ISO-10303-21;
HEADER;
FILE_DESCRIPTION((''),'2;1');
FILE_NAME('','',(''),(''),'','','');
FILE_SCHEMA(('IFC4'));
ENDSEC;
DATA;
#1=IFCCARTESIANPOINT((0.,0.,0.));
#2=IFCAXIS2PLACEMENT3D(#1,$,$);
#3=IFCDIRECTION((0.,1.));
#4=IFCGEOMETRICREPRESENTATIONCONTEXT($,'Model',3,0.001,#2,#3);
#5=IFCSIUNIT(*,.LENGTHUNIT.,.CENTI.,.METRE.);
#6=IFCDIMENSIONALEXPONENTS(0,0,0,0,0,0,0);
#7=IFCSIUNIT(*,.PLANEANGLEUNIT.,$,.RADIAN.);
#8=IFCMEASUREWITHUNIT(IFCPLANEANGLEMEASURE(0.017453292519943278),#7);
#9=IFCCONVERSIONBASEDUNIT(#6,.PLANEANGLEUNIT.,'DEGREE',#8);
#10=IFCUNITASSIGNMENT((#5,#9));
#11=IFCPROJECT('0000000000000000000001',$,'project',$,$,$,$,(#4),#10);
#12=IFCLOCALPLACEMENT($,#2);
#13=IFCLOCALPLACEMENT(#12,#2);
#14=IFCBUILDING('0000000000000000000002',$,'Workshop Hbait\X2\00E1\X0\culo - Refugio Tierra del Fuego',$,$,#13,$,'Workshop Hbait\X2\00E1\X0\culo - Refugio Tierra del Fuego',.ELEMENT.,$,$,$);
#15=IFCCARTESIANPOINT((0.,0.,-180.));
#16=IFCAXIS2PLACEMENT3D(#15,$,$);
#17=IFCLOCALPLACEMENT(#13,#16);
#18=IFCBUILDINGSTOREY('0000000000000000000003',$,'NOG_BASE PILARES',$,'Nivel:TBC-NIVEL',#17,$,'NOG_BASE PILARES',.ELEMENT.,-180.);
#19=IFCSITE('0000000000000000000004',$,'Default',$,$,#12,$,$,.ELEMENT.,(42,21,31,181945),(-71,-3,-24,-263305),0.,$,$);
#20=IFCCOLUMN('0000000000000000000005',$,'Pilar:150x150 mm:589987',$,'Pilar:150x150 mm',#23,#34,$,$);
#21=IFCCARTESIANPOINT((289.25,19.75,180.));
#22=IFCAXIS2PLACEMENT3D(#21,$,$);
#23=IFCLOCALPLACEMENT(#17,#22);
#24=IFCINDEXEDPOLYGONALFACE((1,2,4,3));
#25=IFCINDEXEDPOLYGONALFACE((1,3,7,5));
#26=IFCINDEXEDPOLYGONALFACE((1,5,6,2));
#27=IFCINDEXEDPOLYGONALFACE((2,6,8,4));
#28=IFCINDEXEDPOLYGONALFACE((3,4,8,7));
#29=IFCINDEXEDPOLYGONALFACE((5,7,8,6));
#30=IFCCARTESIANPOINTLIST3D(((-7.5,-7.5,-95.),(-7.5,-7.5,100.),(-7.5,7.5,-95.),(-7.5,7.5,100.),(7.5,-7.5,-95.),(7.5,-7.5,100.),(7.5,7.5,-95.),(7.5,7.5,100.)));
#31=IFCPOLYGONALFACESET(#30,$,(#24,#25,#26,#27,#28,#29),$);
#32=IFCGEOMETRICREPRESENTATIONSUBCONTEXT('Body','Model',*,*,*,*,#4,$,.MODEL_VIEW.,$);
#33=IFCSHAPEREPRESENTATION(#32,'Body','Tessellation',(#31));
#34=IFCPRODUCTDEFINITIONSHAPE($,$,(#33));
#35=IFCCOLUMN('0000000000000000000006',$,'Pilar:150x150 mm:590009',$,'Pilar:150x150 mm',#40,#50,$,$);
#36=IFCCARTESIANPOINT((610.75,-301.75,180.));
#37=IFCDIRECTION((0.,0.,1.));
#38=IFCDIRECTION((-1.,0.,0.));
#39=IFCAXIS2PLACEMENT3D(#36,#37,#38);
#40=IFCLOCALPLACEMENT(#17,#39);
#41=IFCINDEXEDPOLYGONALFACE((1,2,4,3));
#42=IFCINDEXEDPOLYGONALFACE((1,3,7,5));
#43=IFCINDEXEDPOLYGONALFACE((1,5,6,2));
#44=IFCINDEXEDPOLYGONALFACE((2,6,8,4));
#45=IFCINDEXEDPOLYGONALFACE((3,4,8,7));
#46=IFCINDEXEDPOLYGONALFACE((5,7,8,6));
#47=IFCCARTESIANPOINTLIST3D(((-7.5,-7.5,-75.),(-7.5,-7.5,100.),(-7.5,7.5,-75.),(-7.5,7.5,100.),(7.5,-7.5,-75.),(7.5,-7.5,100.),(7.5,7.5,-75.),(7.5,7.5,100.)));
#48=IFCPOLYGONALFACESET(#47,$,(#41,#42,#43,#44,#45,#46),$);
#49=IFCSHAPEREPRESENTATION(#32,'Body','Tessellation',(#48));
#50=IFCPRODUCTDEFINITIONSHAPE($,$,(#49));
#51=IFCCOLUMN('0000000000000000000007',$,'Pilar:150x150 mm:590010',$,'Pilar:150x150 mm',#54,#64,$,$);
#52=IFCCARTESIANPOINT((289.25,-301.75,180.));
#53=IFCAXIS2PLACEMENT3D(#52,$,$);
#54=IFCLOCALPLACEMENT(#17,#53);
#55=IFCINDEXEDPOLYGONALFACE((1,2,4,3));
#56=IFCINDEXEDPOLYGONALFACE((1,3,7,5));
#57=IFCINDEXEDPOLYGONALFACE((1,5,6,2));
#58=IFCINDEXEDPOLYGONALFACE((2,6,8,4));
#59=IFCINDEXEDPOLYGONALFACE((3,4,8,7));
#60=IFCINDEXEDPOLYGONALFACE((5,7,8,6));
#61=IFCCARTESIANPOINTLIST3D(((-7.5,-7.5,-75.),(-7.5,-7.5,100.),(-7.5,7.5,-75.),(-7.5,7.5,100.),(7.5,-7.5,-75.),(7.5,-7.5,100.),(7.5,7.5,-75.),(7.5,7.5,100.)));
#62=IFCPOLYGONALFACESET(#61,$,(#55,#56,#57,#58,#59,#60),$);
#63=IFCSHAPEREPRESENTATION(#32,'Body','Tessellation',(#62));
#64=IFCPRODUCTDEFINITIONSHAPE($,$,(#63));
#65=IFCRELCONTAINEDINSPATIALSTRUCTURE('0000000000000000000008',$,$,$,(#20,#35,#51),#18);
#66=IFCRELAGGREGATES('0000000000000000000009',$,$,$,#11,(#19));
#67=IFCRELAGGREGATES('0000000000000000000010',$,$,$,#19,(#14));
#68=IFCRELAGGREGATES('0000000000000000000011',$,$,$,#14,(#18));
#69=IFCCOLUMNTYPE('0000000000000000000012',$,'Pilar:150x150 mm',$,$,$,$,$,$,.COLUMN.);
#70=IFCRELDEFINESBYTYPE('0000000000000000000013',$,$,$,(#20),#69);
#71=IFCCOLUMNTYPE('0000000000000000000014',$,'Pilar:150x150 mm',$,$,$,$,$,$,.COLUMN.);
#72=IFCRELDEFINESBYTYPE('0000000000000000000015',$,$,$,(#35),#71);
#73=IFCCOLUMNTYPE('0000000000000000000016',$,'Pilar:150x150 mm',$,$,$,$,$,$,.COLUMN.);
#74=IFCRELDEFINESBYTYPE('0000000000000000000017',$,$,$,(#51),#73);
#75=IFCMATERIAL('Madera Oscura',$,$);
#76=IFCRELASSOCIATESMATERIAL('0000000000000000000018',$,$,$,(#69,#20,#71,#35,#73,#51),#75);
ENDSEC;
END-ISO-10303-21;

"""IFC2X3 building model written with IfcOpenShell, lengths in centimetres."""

from ifc_helpers import new_model, entity, si_unit, converted_unit, direction, frame, origin, origin_2d_with_axis, place, context, subcontext, project, spatial, rectangle, extrude, source, transform, mapped, material, type_object, type_shapes, element, save


model = new_model("IFC2X3")

# Units and contexts
model_context = context("Model", 3, precision=0.001, world=origin(), true_north=direction((0.0, 1.0)))
body_context = subcontext(model_context, "Body", "Model", "MODEL_VIEW")
ifc_project = project(units=[si_unit("LENGTHUNIT", "METRE", prefix="CENTI"), converted_unit("PLANEANGLEUNIT", "DEGREE", entity("IfcPlaneAngleMeasure", 0.017453292519943278), si_unit("PLANEANGLEUNIT", "RADIAN"), dimensions=[0, 0, 0, 0, 0, 0, 0])], contexts=[model_context])

# Site, building, storey
site_placement = place(None, origin())
site = spatial("IfcSite", under=ifc_project, at=site_placement, Name="Default", CompositionType="ELEMENT", RefLatitude=(42, 21, 31, 181945), RefLongitude=(-71, -3, -24, -263305), RefElevation=0.0)
building_placement = place(site_placement, origin())
building = spatial("IfcBuilding", under=site, at=building_placement, Name="Workshop Hbaitáculo - Refugio Tierra del Fuego", LongName="Workshop Hbaitáculo - Refugio Tierra del Fuego", CompositionType="ELEMENT")
storey_placement = place(building_placement, frame((0.0, 0.0, -180.0)))
storey = spatial("IfcBuildingStorey", under=building, at=storey_placement, Name="NOG_BASE PILARES", ObjectType="Nivel:TBC-NIVEL", LongName="NOG_BASE PILARES", CompositionType="ELEMENT", Elevation=-180.0)

# Columns
ifc_material = material(Name="Madera Oscura")
column_type_1 = type_object("IfcColumnType", Name="Pilar:150x150 mm", PredefinedType="COLUMN", material=ifc_material)
shared_shape_1 = source(origin(), body_context, "Body", "SweptSolid", [
    extrude(rectangle(XDim=15.0, YDim=15.0, at=origin_2d_with_axis()), frame((0.0, 0.0, -95.0), z_axis=(0.0, 0.0, 1.0), x_axis=(-1.0, 0.0, 0.0)), (0.0, 0.0, 1.0), 195.0),
])
type_shapes(column_type_1, [shared_shape_1])
column_1_placement = place(storey_placement, frame((289.25, 19.75, 180.0)))
element("IfcColumn", 1, at=column_1_placement, inside=storey, type_object=column_type_1, material=ifc_material, Name="Pilar:150x150 mm:589987", ObjectType="Pilar:150x150 mm", context=body_context, shape_type="MappedRepresentation", body=[
    mapped(shared_shape_1, transform((0.0, 0.0, 0.0), scale=1.0)),
])
column_type_2 = type_object("IfcColumnType", Name="Pilar:150x150 mm", PredefinedType="COLUMN", material=ifc_material)
shared_shape_2 = source(origin(), body_context, "Body", "SweptSolid", [
    extrude(rectangle(XDim=15.0, YDim=15.0, at=origin_2d_with_axis()), frame((0.0, 0.0, -75.0), z_axis=(0.0, 0.0, 1.0), x_axis=(-1.0, 0.0, 0.0)), (0.0, 0.0, 1.0), 175.0),
])
type_shapes(column_type_2, [shared_shape_2])
column_2_placement = place(storey_placement, frame((610.75, -301.75, 180.0), z_axis=(0.0, 0.0, 1.0), x_axis=(-1.0, 0.0, 0.0)))
element("IfcColumn", 2, at=column_2_placement, inside=storey, type_object=column_type_2, material=ifc_material, Name="Pilar:150x150 mm:590009", ObjectType="Pilar:150x150 mm", context=body_context, shape_type="MappedRepresentation", body=[
    mapped(shared_shape_2, transform((0.0, 0.0, 0.0), scale=1.0)),
])
column_type_3 = type_object("IfcColumnType", Name="Pilar:150x150 mm", PredefinedType="COLUMN", material=ifc_material)
shared_shape_3 = source(origin(), body_context, "Body", "SweptSolid", [
    extrude(rectangle(XDim=15.0, YDim=15.0, at=origin_2d_with_axis()), frame((0.0, 0.0, -75.0), z_axis=(0.0, 0.0, 1.0), x_axis=(0.0, 1.0, 0.0)), (0.0, 0.0, 1.0), 175.0),
])
type_shapes(column_type_3, [shared_shape_3])
column_3_placement = place(storey_placement, frame((289.25, -301.75, 180.0)))
element("IfcColumn", 3, at=column_3_placement, inside=storey, type_object=column_type_3, material=ifc_material, Name="Pilar:150x150 mm:590010", ObjectType="Pilar:150x150 mm", context=body_context, shape_type="MappedRepresentation", body=[
    mapped(shared_shape_3, transform((0.0, 0.0, 0.0), scale=1.0)),
])

save(model, "model.ifc")
